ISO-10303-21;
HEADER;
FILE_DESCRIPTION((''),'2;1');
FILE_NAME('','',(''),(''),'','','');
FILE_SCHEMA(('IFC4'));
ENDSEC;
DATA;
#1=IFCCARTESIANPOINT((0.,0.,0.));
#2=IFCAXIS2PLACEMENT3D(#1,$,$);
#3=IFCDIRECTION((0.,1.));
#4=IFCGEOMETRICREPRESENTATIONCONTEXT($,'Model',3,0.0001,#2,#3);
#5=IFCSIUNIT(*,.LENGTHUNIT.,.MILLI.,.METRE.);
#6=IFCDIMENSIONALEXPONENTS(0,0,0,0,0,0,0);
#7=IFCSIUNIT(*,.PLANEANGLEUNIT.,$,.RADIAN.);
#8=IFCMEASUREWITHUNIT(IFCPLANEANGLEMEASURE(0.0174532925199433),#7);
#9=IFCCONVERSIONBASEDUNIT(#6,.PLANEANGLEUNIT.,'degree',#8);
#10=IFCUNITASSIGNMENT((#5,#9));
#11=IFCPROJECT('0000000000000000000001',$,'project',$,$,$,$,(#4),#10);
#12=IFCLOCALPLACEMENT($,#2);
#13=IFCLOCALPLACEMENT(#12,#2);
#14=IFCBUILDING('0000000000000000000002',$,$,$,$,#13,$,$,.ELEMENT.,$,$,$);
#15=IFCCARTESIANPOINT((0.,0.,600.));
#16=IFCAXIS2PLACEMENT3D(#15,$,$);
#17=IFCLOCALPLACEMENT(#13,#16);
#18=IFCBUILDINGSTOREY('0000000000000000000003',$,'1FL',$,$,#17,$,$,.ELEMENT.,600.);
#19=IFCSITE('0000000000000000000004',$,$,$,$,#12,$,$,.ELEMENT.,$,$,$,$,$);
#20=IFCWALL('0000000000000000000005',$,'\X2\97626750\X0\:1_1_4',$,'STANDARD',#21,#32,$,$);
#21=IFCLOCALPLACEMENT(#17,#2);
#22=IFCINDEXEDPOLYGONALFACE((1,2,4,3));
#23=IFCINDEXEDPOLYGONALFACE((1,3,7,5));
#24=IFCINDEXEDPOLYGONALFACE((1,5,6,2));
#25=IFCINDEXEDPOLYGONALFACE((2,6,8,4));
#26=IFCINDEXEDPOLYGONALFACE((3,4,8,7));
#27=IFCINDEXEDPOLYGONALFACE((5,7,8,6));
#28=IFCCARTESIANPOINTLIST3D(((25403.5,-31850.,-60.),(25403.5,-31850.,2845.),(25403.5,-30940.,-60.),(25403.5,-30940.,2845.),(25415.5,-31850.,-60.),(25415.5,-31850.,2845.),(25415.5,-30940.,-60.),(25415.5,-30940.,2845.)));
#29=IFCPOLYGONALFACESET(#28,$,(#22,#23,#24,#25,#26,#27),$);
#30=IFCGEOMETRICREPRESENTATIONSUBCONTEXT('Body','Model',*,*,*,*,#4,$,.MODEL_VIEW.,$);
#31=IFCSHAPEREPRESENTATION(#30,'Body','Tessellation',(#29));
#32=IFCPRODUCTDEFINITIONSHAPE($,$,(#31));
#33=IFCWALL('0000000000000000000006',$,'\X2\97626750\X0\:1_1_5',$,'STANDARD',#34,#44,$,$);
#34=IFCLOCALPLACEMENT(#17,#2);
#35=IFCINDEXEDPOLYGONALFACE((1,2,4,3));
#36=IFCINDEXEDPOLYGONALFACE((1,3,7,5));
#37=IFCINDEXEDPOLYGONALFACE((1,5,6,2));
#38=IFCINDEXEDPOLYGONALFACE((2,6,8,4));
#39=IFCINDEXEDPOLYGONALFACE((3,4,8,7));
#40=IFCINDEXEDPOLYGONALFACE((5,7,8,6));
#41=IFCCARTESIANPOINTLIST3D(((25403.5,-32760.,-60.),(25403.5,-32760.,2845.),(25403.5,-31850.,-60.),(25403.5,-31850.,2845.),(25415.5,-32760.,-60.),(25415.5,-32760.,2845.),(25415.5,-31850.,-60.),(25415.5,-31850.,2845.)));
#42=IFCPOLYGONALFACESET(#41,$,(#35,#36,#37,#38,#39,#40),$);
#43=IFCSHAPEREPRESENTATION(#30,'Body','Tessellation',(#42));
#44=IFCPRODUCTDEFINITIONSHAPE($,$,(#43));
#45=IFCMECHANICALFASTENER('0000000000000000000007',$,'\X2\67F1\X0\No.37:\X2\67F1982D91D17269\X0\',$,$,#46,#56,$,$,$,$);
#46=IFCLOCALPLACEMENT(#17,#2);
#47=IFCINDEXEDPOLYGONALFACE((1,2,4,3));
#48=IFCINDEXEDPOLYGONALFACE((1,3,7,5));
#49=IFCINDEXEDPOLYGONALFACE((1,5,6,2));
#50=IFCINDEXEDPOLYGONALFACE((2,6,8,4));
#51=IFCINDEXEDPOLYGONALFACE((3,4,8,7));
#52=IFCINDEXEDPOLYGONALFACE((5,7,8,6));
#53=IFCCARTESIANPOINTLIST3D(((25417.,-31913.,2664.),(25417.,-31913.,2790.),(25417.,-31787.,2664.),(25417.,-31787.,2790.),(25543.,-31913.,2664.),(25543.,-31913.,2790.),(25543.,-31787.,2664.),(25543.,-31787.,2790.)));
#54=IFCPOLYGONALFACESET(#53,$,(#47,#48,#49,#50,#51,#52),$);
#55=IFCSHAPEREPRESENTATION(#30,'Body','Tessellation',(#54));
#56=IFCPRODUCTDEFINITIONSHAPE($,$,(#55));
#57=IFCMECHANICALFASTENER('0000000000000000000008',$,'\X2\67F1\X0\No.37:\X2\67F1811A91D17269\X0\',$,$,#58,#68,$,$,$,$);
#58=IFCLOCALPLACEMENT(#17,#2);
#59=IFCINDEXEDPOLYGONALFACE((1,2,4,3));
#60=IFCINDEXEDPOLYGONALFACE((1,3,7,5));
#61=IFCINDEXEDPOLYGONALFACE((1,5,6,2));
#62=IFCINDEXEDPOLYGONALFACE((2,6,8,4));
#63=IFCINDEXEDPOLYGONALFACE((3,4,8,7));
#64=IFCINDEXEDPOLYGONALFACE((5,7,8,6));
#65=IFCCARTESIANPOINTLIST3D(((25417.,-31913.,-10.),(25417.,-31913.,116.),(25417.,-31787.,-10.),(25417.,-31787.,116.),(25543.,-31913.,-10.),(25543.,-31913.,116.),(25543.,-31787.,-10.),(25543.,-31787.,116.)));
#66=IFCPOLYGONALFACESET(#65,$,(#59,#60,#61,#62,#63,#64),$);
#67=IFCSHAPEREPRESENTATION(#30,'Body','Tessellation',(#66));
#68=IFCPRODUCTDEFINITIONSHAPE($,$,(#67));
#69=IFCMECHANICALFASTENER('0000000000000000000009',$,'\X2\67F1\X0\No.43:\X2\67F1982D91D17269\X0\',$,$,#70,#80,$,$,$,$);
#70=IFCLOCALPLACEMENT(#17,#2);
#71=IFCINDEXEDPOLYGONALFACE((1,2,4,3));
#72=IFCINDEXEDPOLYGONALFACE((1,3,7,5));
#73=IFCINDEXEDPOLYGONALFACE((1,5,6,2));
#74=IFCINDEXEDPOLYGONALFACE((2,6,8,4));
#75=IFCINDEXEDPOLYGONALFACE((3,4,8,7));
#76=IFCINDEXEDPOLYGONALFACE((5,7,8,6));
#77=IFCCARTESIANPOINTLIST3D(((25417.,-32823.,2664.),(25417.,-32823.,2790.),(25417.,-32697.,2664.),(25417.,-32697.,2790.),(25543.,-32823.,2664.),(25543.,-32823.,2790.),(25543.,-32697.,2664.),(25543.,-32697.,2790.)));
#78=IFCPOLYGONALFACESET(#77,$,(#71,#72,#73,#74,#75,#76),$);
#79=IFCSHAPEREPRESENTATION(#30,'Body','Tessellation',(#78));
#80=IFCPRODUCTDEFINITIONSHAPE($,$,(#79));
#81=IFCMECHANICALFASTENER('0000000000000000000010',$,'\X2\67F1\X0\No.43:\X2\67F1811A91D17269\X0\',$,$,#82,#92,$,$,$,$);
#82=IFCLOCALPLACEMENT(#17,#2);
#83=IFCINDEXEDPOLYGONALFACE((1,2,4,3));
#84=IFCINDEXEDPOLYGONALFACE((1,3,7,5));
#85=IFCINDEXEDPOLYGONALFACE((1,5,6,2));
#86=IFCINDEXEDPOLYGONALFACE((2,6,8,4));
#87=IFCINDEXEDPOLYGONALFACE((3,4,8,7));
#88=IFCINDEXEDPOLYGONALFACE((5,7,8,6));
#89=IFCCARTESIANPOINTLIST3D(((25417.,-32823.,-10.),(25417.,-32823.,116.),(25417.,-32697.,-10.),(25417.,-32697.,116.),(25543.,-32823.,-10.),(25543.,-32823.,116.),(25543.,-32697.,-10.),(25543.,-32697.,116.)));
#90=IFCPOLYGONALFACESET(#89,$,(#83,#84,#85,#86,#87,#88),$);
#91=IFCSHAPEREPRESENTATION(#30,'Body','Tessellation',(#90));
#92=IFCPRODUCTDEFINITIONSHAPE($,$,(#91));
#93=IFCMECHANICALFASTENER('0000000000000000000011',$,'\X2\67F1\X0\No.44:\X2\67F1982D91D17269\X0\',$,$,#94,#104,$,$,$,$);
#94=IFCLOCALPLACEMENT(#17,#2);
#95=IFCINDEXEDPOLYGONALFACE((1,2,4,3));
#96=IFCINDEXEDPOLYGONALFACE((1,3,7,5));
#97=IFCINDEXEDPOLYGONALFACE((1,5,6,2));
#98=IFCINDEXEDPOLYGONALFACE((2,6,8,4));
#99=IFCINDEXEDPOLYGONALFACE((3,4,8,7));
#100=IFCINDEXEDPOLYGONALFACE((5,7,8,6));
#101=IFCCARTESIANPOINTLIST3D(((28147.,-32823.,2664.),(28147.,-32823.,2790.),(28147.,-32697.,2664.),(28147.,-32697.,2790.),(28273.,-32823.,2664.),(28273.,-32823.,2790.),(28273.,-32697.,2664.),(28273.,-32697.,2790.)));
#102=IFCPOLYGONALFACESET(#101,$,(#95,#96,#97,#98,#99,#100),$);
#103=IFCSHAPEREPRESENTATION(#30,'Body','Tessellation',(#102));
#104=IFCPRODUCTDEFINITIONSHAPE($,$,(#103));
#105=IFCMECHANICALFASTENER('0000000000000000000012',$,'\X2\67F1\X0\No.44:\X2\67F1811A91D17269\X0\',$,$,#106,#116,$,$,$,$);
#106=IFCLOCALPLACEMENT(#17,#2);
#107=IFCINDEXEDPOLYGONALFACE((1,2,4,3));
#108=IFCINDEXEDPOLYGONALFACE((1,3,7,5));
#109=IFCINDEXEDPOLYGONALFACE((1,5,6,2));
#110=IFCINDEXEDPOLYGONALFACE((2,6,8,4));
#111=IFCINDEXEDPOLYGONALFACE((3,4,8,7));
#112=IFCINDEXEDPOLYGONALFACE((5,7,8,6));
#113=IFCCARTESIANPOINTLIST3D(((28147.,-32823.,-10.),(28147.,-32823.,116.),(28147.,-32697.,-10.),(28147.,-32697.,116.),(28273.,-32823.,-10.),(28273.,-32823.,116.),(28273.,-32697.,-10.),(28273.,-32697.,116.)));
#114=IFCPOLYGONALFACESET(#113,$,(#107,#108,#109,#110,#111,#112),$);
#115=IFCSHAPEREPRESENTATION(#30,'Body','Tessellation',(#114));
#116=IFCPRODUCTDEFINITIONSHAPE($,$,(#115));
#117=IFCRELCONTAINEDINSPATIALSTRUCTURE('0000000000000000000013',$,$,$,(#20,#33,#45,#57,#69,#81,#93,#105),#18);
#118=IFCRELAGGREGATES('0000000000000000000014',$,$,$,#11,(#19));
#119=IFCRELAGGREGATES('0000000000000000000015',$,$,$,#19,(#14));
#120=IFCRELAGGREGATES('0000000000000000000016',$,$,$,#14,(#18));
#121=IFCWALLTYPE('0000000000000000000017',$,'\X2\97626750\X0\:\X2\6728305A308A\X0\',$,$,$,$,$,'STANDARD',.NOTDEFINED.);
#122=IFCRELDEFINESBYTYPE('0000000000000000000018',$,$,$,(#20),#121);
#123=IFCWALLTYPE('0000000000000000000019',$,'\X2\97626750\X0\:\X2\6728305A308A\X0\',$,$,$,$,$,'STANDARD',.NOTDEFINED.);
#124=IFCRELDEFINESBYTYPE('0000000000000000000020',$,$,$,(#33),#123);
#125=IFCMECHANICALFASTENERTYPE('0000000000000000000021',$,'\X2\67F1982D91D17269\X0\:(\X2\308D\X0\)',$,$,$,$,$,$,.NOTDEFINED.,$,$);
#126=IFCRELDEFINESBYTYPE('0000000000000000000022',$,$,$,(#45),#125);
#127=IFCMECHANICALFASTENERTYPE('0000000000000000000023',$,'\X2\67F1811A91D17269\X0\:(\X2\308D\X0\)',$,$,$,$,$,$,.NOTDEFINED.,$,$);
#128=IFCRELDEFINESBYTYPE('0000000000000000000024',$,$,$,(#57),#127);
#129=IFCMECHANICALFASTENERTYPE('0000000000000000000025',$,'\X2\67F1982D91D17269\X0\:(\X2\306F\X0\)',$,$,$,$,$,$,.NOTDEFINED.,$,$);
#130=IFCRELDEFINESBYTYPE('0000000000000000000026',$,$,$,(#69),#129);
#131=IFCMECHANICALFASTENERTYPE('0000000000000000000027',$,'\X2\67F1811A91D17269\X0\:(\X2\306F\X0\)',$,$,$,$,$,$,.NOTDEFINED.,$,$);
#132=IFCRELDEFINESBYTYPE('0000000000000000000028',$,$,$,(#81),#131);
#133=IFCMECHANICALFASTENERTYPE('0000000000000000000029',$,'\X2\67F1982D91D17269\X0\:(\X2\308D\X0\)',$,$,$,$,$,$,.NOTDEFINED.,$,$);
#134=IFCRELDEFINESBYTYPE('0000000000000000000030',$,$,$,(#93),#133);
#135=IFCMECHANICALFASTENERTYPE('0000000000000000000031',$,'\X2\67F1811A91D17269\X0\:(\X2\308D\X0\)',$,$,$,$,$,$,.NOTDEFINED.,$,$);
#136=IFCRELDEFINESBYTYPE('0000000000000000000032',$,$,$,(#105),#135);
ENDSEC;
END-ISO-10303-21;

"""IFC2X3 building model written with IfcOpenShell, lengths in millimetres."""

from ifc_helpers import new_model, entity, si_unit, converted_unit, direction, frame, origin, origin_with_axes, origin_2d, place, context, subcontext, project, spatial, polyline, rectangle, outline, extrude, type_object, element, save


model = new_model("IFC2X3")

# Units and contexts
model_context = context("Model", 3, precision=0.0001, world=origin(), true_north=direction((0.0, 1.0)))
body_context = subcontext(model_context, "Body", "Model", "MODEL_VIEW")
ifc_project = project(units=[si_unit("LENGTHUNIT", "METRE", prefix="MILLI"), converted_unit("PLANEANGLEUNIT", "degree", entity("IfcPlaneAngleMeasure", 0.0174532925199433), si_unit("PLANEANGLEUNIT", "RADIAN"), dimensions=[0, 0, 0, 0, 0, 0, 0])], contexts=[model_context])

# Site, building, storey
site_placement = place(None, origin())
site = spatial("IfcSite", under=ifc_project, at=site_placement, CompositionType="ELEMENT")
building_placement = place(site_placement, origin())
building = spatial("IfcBuilding", under=site, at=building_placement, CompositionType="ELEMENT")
storey_placement = place(building_placement, frame((0.0, 0.0, 600.0)))
storey = spatial("IfcBuildingStorey", under=building, at=storey_placement, Name="1FL", CompositionType="ELEMENT", Elevation=600.0)

# Walls
wall_type_1 = type_object("IfcWallType", Name="面材:木ずり", ElementType="STANDARD", PredefinedType="NOTDEFINED")
wall_1_placement = place(storey_placement, frame((25415.5, -31395.0, -60.0), z_axis=(-1.0, 0.0, 0.0), x_axis=(0.0, -1.0, 0.0)))
element("IfcWall", 1, at=wall_1_placement, inside=storey, type_object=wall_type_1, Name="面材:1_1_4", ObjectType="STANDARD", context=body_context, shape_type="SweptSolid", body=[
    extrude(outline(polyline([(455.0, 0.0, 0.0), (-455.0, 0.0, 0.0), (-455.0, 2905.0, 0.0), (455.0, 2905.0, 0.0), (455.0, 0.0, 0.0)])), origin_with_axes(), (0.0, 0.0, 1.0), 12.0),
])
wall_type_2 = type_object("IfcWallType", Name="面材:木ずり", ElementType="STANDARD", PredefinedType="NOTDEFINED")
wall_2_placement = place(storey_placement, frame((25415.5, -32305.0, -60.0), z_axis=(-1.0, 0.0, 0.0), x_axis=(0.0, -1.0, 0.0)))
element("IfcWall", 2, at=wall_2_placement, inside=storey, type_object=wall_type_2, Name="面材:1_1_5", ObjectType="STANDARD", context=body_context, shape_type="SweptSolid", body=[
    extrude(outline(polyline([(455.0, 0.0, 0.0), (-455.0, 0.0, 0.0), (-455.0, 2905.0, 0.0), (455.0, 2905.0, 0.0), (455.0, 0.0, 0.0)])), origin_with_axes(), (0.0, 0.0, 1.0), 12.0),
])

# Mechanical fasteners
mechanical_fastener_type_1 = type_object("IfcMechanicalFastenerType", Name="柱頭金物:(ろ)")
mechanical_fastener_1_placement = place(storey_placement, frame((25480.0, -31850.0, 2664.0)))
element("IfcMechanicalFastener", 3, at=mechanical_fastener_1_placement, inside=storey, type_object=mechanical_fastener_type_1, Name="柱No.37:柱頭金物", context=body_context, shape_type="SweptSolid", body=[
    extrude(rectangle(XDim=126.0, YDim=126.0, at=origin_2d()), origin_with_axes(), (0.0, 0.0, 1.0), 126.0),
])
mechanical_fastener_type_2 = type_object("IfcMechanicalFastenerType", Name="柱脚金物:(ろ)")
mechanical_fastener_2_placement = place(storey_placement, frame((25480.0, -31850.0, -10.0)))
element("IfcMechanicalFastener", 4, at=mechanical_fastener_2_placement, inside=storey, type_object=mechanical_fastener_type_2, Name="柱No.37:柱脚金物", context=body_context, shape_type="SweptSolid", body=[
    extrude(rectangle(XDim=126.0, YDim=126.0, at=origin_2d()), origin_with_axes(), (0.0, 0.0, 1.0), 126.0),
])
mechanical_fastener_type_3 = type_object("IfcMechanicalFastenerType", Name="柱頭金物:(は)")
mechanical_fastener_3_placement = place(storey_placement, frame((25480.0, -32760.0, 2664.0)))
element("IfcMechanicalFastener", 5, at=mechanical_fastener_3_placement, inside=storey, type_object=mechanical_fastener_type_3, Name="柱No.43:柱頭金物", context=body_context, shape_type="SweptSolid", body=[
    extrude(rectangle(XDim=126.0, YDim=126.0, at=origin_2d()), origin_with_axes(), (0.0, 0.0, 1.0), 126.0),
])
mechanical_fastener_type_4 = type_object("IfcMechanicalFastenerType", Name="柱脚金物:(は)")
mechanical_fastener_4_placement = place(storey_placement, frame((25480.0, -32760.0, -10.0)))
element("IfcMechanicalFastener", 6, at=mechanical_fastener_4_placement, inside=storey, type_object=mechanical_fastener_type_4, Name="柱No.43:柱脚金物", context=body_context, shape_type="SweptSolid", body=[
    extrude(rectangle(XDim=126.0, YDim=126.0, at=origin_2d()), origin_with_axes(), (0.0, 0.0, 1.0), 126.0),
])
mechanical_fastener_type_5 = type_object("IfcMechanicalFastenerType", Name="柱頭金物:(ろ)")
mechanical_fastener_5_placement = place(storey_placement, frame((28210.0, -32760.0, 2664.0)))
element("IfcMechanicalFastener", 7, at=mechanical_fastener_5_placement, inside=storey, type_object=mechanical_fastener_type_5, Name="柱No.44:柱頭金物", context=body_context, shape_type="SweptSolid", body=[
    extrude(rectangle(XDim=126.0, YDim=126.0, at=origin_2d()), origin_with_axes(), (0.0, 0.0, 1.0), 126.0),
])
mechanical_fastener_type_6 = type_object("IfcMechanicalFastenerType", Name="柱脚金物:(ろ)")
mechanical_fastener_6_placement = place(storey_placement, frame((28210.0, -32760.0, -10.0)))
element("IfcMechanicalFastener", 8, at=mechanical_fastener_6_placement, inside=storey, type_object=mechanical_fastener_type_6, Name="柱No.44:柱脚金物", context=body_context, shape_type="SweptSolid", body=[
    extrude(rectangle(XDim=126.0, YDim=126.0, at=origin_2d()), origin_with_axes(), (0.0, 0.0, 1.0), 126.0),
])

save(model, "model.ifc")
